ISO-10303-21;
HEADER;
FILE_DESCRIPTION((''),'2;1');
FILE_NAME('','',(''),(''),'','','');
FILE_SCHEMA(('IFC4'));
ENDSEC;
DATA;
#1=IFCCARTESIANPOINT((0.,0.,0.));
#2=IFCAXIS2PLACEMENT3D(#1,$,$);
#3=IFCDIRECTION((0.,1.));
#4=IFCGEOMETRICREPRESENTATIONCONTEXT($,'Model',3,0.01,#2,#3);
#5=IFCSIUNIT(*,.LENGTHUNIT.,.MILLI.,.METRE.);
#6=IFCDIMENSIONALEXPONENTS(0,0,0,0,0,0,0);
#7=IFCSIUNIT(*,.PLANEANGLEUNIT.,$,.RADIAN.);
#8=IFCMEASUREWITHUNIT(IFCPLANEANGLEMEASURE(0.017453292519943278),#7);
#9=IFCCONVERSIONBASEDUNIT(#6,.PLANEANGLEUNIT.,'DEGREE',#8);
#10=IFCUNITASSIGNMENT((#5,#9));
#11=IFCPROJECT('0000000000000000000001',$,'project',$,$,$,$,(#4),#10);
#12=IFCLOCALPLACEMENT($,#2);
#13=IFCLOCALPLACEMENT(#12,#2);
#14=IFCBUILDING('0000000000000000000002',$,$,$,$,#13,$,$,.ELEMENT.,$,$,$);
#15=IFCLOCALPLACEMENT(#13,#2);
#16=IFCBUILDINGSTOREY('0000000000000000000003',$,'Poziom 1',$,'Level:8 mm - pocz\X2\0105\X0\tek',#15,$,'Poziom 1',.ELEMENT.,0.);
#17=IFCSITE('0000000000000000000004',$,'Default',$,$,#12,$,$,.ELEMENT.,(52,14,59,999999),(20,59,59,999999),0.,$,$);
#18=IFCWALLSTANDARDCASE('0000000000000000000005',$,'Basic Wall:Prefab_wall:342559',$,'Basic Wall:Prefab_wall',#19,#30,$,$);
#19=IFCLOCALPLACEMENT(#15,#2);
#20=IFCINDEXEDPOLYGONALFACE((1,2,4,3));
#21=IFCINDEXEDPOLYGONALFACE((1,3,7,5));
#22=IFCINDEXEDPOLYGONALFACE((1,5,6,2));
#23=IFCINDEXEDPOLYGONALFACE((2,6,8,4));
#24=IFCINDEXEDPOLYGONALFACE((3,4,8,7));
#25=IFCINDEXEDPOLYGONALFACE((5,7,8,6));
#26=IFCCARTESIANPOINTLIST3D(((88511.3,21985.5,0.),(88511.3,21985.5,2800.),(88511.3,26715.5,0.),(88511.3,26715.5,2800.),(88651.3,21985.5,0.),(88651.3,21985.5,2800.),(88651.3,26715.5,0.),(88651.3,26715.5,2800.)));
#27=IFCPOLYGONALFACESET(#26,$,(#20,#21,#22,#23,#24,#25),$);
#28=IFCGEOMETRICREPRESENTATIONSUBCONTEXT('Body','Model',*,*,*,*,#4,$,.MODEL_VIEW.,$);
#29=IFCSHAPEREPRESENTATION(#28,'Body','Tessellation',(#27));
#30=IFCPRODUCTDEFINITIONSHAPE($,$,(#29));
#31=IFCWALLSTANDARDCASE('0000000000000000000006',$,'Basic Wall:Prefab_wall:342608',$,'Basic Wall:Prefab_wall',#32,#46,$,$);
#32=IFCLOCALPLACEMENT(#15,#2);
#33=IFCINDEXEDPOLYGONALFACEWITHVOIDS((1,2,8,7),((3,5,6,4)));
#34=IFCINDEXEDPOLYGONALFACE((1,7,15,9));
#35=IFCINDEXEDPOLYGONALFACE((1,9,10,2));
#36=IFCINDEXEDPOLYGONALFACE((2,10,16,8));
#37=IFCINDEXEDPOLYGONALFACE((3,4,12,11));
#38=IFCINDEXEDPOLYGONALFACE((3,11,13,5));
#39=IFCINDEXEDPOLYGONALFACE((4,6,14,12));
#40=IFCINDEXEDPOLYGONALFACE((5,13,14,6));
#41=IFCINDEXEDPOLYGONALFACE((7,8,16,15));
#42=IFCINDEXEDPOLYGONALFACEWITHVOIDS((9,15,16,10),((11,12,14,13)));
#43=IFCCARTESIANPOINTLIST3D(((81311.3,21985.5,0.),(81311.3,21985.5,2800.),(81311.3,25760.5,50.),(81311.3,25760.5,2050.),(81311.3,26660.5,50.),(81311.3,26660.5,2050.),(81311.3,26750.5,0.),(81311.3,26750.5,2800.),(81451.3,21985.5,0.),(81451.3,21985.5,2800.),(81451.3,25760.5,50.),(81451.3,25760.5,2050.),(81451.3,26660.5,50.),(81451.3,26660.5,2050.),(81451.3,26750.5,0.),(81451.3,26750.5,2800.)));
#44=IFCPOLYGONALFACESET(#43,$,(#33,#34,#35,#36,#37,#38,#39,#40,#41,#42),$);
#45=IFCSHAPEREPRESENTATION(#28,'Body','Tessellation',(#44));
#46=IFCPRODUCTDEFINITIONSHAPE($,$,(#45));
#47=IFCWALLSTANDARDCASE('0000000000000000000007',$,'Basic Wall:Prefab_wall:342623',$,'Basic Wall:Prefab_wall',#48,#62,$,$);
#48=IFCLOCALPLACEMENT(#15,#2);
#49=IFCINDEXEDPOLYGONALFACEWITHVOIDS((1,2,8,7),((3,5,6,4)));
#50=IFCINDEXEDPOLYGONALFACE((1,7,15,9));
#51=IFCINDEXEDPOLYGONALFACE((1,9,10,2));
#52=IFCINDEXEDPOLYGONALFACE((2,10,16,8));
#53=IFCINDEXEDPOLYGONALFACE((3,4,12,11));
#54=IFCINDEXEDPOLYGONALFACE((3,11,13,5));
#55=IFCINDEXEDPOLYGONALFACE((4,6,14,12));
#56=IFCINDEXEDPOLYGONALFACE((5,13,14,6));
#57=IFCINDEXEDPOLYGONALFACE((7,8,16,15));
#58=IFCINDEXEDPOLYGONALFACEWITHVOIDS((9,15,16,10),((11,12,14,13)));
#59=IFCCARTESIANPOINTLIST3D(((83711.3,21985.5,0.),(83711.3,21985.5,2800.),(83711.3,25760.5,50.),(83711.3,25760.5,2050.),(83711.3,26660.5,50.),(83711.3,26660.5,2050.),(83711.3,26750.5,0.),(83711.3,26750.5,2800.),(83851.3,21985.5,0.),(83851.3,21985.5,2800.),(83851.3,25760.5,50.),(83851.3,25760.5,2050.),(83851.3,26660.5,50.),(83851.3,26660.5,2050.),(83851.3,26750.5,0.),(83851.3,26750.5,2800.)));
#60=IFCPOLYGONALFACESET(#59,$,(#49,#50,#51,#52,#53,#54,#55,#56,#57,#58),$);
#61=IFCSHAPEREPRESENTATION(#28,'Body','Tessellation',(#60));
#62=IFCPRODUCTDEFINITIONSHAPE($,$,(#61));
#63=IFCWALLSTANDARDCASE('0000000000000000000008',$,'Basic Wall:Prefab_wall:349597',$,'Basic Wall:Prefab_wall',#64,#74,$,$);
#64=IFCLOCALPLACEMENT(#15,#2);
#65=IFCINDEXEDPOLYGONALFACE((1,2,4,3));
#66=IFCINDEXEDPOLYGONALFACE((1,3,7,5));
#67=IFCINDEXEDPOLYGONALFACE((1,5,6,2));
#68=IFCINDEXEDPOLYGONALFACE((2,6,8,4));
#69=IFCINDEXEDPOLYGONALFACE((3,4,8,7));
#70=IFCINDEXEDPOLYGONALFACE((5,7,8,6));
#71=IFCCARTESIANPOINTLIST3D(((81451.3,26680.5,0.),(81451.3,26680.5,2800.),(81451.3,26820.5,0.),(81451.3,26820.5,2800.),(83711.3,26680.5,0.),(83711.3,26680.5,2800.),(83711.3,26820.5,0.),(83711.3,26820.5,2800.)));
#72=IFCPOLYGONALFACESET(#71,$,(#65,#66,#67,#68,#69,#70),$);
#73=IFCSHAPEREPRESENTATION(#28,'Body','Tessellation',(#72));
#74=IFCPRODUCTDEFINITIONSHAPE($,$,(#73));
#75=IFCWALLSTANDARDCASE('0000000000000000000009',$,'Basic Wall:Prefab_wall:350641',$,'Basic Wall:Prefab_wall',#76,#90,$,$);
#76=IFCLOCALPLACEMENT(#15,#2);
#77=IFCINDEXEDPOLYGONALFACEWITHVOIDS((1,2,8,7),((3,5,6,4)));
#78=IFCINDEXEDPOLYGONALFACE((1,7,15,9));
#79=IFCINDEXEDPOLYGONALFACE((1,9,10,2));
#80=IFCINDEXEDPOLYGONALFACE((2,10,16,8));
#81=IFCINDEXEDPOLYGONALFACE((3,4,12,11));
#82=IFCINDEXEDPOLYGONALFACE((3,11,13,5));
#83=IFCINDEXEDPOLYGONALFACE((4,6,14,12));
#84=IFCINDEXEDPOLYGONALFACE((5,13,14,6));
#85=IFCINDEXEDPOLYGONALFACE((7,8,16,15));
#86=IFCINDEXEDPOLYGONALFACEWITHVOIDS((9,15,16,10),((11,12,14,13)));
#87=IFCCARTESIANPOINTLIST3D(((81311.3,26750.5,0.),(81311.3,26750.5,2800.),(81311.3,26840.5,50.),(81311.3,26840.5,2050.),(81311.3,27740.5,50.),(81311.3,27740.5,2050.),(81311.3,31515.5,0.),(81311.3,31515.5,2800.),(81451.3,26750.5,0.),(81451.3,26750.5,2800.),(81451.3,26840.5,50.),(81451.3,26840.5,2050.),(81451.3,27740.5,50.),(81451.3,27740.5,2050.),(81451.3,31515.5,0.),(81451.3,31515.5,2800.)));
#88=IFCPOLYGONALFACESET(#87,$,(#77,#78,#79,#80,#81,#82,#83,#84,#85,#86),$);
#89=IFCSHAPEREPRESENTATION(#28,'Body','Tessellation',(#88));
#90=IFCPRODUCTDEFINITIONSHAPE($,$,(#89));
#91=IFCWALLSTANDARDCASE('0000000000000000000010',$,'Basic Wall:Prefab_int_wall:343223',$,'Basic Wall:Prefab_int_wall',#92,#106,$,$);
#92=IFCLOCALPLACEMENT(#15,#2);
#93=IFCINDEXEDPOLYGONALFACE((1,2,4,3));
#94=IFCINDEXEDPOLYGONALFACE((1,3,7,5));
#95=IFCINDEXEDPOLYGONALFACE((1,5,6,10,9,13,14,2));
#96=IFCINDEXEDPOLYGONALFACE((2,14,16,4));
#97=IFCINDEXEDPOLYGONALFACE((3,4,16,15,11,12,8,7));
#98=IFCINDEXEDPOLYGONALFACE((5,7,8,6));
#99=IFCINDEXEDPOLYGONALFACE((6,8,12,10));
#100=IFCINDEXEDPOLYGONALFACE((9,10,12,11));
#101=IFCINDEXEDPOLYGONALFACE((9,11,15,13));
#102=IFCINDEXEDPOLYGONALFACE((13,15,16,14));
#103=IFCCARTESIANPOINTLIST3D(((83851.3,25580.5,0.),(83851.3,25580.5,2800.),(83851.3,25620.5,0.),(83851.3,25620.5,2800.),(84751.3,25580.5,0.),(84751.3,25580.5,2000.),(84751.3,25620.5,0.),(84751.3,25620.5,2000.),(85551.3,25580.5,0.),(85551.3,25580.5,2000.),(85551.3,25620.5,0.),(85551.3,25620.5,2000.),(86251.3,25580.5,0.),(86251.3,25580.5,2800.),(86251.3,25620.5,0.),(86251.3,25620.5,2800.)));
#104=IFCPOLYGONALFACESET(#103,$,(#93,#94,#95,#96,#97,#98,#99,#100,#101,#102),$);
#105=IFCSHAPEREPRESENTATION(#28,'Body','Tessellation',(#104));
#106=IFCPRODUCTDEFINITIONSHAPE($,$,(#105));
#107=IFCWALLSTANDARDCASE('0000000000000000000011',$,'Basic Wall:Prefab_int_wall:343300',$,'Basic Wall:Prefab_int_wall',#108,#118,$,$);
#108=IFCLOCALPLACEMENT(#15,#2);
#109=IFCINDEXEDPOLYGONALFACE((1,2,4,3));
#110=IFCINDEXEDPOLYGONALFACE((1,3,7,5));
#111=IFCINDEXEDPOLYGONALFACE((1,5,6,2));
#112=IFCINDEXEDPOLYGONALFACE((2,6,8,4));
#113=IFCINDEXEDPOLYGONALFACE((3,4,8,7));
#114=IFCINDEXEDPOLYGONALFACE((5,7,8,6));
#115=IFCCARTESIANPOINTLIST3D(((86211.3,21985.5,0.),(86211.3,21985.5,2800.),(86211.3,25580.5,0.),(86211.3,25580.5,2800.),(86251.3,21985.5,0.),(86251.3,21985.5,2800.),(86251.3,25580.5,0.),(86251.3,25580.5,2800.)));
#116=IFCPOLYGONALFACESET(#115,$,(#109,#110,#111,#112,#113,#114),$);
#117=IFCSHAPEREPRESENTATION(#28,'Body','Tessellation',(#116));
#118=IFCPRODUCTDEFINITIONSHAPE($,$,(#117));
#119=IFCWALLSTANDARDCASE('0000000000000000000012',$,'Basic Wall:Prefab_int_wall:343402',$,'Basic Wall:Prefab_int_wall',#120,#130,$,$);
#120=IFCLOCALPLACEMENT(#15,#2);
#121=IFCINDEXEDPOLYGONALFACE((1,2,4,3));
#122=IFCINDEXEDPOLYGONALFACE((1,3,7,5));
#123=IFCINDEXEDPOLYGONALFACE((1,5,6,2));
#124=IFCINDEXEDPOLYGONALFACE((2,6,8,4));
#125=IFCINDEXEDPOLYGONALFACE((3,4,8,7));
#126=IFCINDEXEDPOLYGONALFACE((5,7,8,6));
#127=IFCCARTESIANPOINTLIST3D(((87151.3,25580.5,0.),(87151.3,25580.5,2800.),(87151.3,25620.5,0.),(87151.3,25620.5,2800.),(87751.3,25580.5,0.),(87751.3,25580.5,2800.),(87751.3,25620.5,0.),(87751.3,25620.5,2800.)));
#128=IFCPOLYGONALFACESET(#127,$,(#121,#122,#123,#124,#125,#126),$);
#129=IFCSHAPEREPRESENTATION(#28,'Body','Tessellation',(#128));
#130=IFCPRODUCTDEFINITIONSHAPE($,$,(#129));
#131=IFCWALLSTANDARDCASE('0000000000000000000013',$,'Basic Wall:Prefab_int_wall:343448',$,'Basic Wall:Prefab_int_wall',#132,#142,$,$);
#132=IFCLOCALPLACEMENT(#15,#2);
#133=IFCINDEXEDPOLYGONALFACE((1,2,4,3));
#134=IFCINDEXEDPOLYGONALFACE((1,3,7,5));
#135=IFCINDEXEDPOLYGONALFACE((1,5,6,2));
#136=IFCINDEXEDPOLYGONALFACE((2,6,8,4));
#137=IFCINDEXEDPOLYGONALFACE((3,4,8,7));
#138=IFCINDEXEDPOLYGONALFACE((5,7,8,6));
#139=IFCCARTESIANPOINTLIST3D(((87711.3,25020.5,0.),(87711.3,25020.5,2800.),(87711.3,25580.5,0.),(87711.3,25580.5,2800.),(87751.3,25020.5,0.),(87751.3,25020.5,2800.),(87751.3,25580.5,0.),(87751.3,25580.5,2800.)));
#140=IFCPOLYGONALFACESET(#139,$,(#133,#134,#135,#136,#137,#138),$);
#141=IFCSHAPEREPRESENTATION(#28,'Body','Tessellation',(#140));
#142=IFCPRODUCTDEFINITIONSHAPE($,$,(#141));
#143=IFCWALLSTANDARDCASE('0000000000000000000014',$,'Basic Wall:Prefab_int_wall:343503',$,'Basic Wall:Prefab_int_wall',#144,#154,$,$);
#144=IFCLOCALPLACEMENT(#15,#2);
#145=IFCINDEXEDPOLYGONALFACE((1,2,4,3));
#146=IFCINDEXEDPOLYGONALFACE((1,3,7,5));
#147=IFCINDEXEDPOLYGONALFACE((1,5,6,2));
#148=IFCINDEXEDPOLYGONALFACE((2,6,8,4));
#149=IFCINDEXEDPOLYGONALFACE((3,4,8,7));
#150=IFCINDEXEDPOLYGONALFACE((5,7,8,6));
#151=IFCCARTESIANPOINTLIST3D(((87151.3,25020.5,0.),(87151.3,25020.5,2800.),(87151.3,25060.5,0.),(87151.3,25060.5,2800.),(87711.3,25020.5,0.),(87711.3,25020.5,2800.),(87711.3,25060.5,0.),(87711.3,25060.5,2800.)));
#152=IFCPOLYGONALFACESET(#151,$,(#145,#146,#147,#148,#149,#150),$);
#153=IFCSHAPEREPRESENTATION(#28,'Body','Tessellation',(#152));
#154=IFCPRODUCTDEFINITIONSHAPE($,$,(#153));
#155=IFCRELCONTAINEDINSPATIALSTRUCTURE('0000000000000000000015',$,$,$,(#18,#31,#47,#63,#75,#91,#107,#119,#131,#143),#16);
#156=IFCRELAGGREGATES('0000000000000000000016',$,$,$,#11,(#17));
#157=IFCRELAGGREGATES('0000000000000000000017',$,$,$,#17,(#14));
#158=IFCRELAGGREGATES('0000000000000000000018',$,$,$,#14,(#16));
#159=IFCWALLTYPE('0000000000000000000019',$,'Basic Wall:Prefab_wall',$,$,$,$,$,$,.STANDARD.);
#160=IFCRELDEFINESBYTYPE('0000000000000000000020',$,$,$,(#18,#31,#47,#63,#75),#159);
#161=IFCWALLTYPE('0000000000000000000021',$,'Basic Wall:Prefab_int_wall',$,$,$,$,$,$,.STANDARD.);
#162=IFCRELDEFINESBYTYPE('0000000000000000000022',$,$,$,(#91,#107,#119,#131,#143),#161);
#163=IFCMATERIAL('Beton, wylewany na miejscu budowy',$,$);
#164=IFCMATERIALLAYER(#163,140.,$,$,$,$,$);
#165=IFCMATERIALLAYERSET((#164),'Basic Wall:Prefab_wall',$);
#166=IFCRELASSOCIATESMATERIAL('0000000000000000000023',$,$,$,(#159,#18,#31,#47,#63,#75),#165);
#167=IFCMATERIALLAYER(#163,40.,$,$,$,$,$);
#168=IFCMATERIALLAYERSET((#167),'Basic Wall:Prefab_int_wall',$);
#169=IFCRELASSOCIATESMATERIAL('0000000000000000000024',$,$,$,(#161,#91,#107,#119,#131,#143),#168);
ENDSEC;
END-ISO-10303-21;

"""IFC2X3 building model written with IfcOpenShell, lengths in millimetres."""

from ifc_helpers import new_model, entity, si_unit, converted_unit, direction, frame, frame_2d, origin, origin_2d_with_axis, place, context, subcontext, project, spatial, rectangle, extrude, material, layer, layer_set, layer_usage, type_object, element, save


model = new_model("IFC2X3")

# Units and contexts
model_context = context("Model", 3, precision=0.01, world=origin(), true_north=direction((0.0, 1.0)))
body_context = subcontext(model_context, "Body", "Model", "MODEL_VIEW")
ifc_project = project(units=[si_unit("LENGTHUNIT", "METRE", prefix="MILLI"), converted_unit("PLANEANGLEUNIT", "DEGREE", entity("IfcPlaneAngleMeasure", 0.017453292519943278), si_unit("PLANEANGLEUNIT", "RADIAN"), dimensions=[0, 0, 0, 0, 0, 0, 0])], contexts=[model_context])

# Site, building, storey
site_placement = place(None, origin())
site = spatial("IfcSite", under=ifc_project, at=site_placement, Name="Default", CompositionType="ELEMENT", RefLatitude=(52, 14, 59, 999999), RefLongitude=(20, 59, 59, 999999), RefElevation=0.0)
building_placement = place(site_placement, origin())
building = spatial("IfcBuilding", under=site, at=building_placement, CompositionType="ELEMENT")
storey_placement = place(building_placement, origin())
storey = spatial("IfcBuildingStorey", under=building, at=storey_placement, Name="Poziom 1", ObjectType="Level:8 mm - początek", LongName="Poziom 1", CompositionType="ELEMENT", Elevation=0.0)

# Wall
ifc_material = material(Name="Beton, wylewany na miejscu budowy")
ifc_layer_1 = layer(ifc_material, 140.0)
ifc_layer_set_1 = layer_set([ifc_layer_1], Name="Basic Wall:Prefab_wall")
ifc_layer_usage_1 = layer_usage(ifc_layer_set_1, "AXIS2", "NEGATIVE", 70.0)
wall_type_1 = type_object("IfcWallType", Name="Basic Wall:Prefab_wall", PredefinedType="STANDARD", material=ifc_layer_set_1)
wall_1_placement = place(storey_placement, frame((88581.3, 21985.5, 0.0), z_axis=(0.0, 0.0, 1.0), x_axis=(0.0, 1.0, 0.0)))
element("IfcWallStandardCase", 1, at=wall_1_placement, inside=storey, type_object=wall_type_1, material=ifc_layer_usage_1, Name="Basic Wall:Prefab_wall:342559", ObjectType="Basic Wall:Prefab_wall", context=body_context, shape_type="SweptSolid", body=[
    extrude(rectangle(XDim=4730.0, YDim=140.0, at=frame_2d((2365.0, 0.0), x_axis=(-1.0, 0.0))), origin(), (0.0, 0.0, 1.0), 2800.0),
])

# Walls, openings
ifc_layer_usage_2 = layer_usage(ifc_layer_set_1, "AXIS2", "NEGATIVE", 70.0)
wall_2_placement = place(storey_placement, frame((81381.3, 21985.5, 0.0), z_axis=(0.0, 0.0, 1.0), x_axis=(0.0, 1.0, 0.0)))
wall_2 = element("IfcWallStandardCase", 2, at=wall_2_placement, inside=storey, type_object=wall_type_1, material=ifc_layer_usage_2, Name="Basic Wall:Prefab_wall:342608", ObjectType="Basic Wall:Prefab_wall", context=body_context, shape_type="SweptSolid", body=[
    extrude(rectangle(XDim=4765.0, YDim=140.0, at=frame_2d((2382.5, 0.0), x_axis=(-1.0, 0.0))), origin(), (0.0, 0.0, 1.0), 2800.0),
])
opening_1_placement = place(wall_2_placement, origin())
element("IfcOpeningElement", 3, at=opening_1_placement, cuts=wall_2, ObjectType="Opening", context=body_context, shape_type="SweptSolid", body=[
    extrude(rectangle(XDim=2000.0, YDim=900.0, at=frame_2d((0.0, 0.0), x_axis=(0.0, 1.0))), frame((4225.0, 70.0, 1050.0), z_axis=(0.0, -1.0, 0.0), x_axis=(1.0, 0.0, 0.0)), (0.0, 0.0, 1.0), 140.0),
])
ifc_layer_usage_3 = layer_usage(ifc_layer_set_1, "AXIS2", "NEGATIVE", 70.0)
wall_3_placement = place(storey_placement, frame((83781.3, 21985.5, 0.0), z_axis=(0.0, 0.0, 1.0), x_axis=(0.0, 1.0, 0.0)))
wall_3 = element("IfcWallStandardCase", 4, at=wall_3_placement, inside=storey, type_object=wall_type_1, material=ifc_layer_usage_3, Name="Basic Wall:Prefab_wall:342623", ObjectType="Basic Wall:Prefab_wall", context=body_context, shape_type="SweptSolid", body=[
    extrude(rectangle(XDim=4765.0, YDim=140.0, at=frame_2d((2382.5, 0.0), x_axis=(-1.0, 0.0))), origin(), (0.0, 0.0, 1.0), 2800.0),
])
opening_2_placement = place(wall_3_placement, origin())
element("IfcOpeningElement", 5, at=opening_2_placement, cuts=wall_3, ObjectType="Opening", context=body_context, shape_type="SweptSolid", body=[
    extrude(rectangle(XDim=2000.0, YDim=900.0, at=frame_2d((0.0, 0.0), x_axis=(0.0, 1.0))), frame((4225.0, 70.0, 1050.0), z_axis=(0.0, -1.0, 0.0), x_axis=(-1.0, 0.0, 0.0)), (0.0, 0.0, 1.0), 140.0),
])

# Wall
ifc_layer_usage_4 = layer_usage(ifc_layer_set_1, "AXIS2", "NEGATIVE", 70.0)
wall_4_placement = place(storey_placement, frame((81451.3, 26750.5, 0.0)))
element("IfcWallStandardCase", 6, at=wall_4_placement, inside=storey, type_object=wall_type_1, material=ifc_layer_usage_4, Name="Basic Wall:Prefab_wall:349597", ObjectType="Basic Wall:Prefab_wall", context=body_context, shape_type="SweptSolid", body=[
    extrude(rectangle(XDim=2260.0, YDim=140.0, at=frame_2d((1130.0, 0.0), x_axis=(-1.0, 0.0))), origin(), (0.0, 0.0, 1.0), 2800.0),
])

# Walls, openings
ifc_layer_usage_5 = layer_usage(ifc_layer_set_1, "AXIS2", "NEGATIVE", 70.0)
wall_5_placement = place(storey_placement, frame((81381.3, 26750.5, 0.0), z_axis=(0.0, 0.0, 1.0), x_axis=(0.0, 1.0, 0.0)))
wall_5 = element("IfcWallStandardCase", 7, at=wall_5_placement, inside=storey, type_object=wall_type_1, material=ifc_layer_usage_5, Name="Basic Wall:Prefab_wall:350641", ObjectType="Basic Wall:Prefab_wall", context=body_context, shape_type="SweptSolid", body=[
    extrude(rectangle(XDim=4765.0, YDim=140.0, at=frame_2d((2382.5, 0.0), x_axis=(-1.0, 0.0))), origin(), (0.0, 0.0, 1.0), 2800.0),
])
opening_3_placement = place(wall_5_placement, origin())
element("IfcOpeningElement", 8, at=opening_3_placement, cuts=wall_5, ObjectType="Opening", context=body_context, shape_type="SweptSolid", body=[
    extrude(rectangle(XDim=2000.0, YDim=900.0, at=origin_2d_with_axis()), frame((540.0, 70.0, 1050.0), z_axis=(0.0, -1.0, 0.0), x_axis=(0.0, 0.0, -1.0)), (0.0, 0.0, 1.0), 140.0),
])
ifc_layer_2 = layer(ifc_material, 40.0)
ifc_layer_set_2 = layer_set([ifc_layer_2], Name="Basic Wall:Prefab_int_wall")
ifc_layer_usage_6 = layer_usage(ifc_layer_set_2, "AXIS2", "NEGATIVE", 20.0)
wall_type_2 = type_object("IfcWallType", Name="Basic Wall:Prefab_int_wall", PredefinedType="STANDARD", material=ifc_layer_set_2)
wall_6_placement = place(storey_placement, frame((83851.3, 25600.5, 0.0)))
wall_6 = element("IfcWallStandardCase", 9, at=wall_6_placement, inside=storey, type_object=wall_type_2, material=ifc_layer_usage_6, Name="Basic Wall:Prefab_int_wall:343223", ObjectType="Basic Wall:Prefab_int_wall", context=body_context, shape_type="SweptSolid", body=[
    extrude(rectangle(XDim=2400.0, YDim=40.0, at=frame_2d((1200.0, 0.0), x_axis=(-1.0, 0.0))), origin(), (0.0, 0.0, 1.0), 2800.0),
])
opening_4_placement = place(wall_6_placement, origin())
element("IfcOpeningElement", 10, at=opening_4_placement, cuts=wall_6, ObjectType="Opening", context=body_context, shape_type="SweptSolid", body=[
    extrude(rectangle(XDim=2000.0, YDim=800.0, at=frame_2d((0.0, 0.0), x_axis=(0.0, 1.0))), frame((1300.0, 20.0, 1000.0), z_axis=(0.0, -1.0, 0.0), x_axis=(1.0, 0.0, 0.0)), (0.0, 0.0, 1.0), 40.0),
])

# Walls
ifc_layer_usage_7 = layer_usage(ifc_layer_set_2, "AXIS2", "NEGATIVE", 20.0)
wall_7_placement = place(storey_placement, frame((86231.3, 25580.5, 0.0), z_axis=(0.0, 0.0, 1.0), x_axis=(0.0, -1.0, 0.0)))
element("IfcWallStandardCase", 11, at=wall_7_placement, inside=storey, type_object=wall_type_2, material=ifc_layer_usage_7, Name="Basic Wall:Prefab_int_wall:343300", ObjectType="Basic Wall:Prefab_int_wall", context=body_context, shape_type="SweptSolid", body=[
    extrude(rectangle(XDim=3595.0, YDim=40.0, at=frame_2d((1797.5, 0.0), x_axis=(-1.0, 0.0))), origin(), (0.0, 0.0, 1.0), 2800.0),
])
ifc_layer_usage_8 = layer_usage(ifc_layer_set_2, "AXIS2", "NEGATIVE", 20.0)
wall_8_placement = place(storey_placement, frame((87151.3, 25600.5, 0.0)))
element("IfcWallStandardCase", 12, at=wall_8_placement, inside=storey, type_object=wall_type_2, material=ifc_layer_usage_8, Name="Basic Wall:Prefab_int_wall:343402", ObjectType="Basic Wall:Prefab_int_wall", context=body_context, shape_type="SweptSolid", body=[
    extrude(rectangle(XDim=600.0, YDim=40.0, at=frame_2d((300.0, 0.0), x_axis=(-1.0, 0.0))), origin(), (0.0, 0.0, 1.0), 2800.0),
])
ifc_layer_usage_9 = layer_usage(ifc_layer_set_2, "AXIS2", "NEGATIVE", 20.0)
wall_9_placement = place(storey_placement, frame((87731.3, 25580.5, 0.0), z_axis=(0.0, 0.0, 1.0), x_axis=(0.0, -1.0, 0.0)))
element("IfcWallStandardCase", 13, at=wall_9_placement, inside=storey, type_object=wall_type_2, material=ifc_layer_usage_9, Name="Basic Wall:Prefab_int_wall:343448", ObjectType="Basic Wall:Prefab_int_wall", context=body_context, shape_type="SweptSolid", body=[
    extrude(rectangle(XDim=560.0, YDim=40.0, at=frame_2d((280.0, 0.0), x_axis=(-1.0, 0.0))), origin(), (0.0, 0.0, 1.0), 2800.0),
])
ifc_layer_usage_10 = layer_usage(ifc_layer_set_2, "AXIS2", "NEGATIVE", 20.0)
wall_10_placement = place(storey_placement, frame((87711.3, 25040.5, 0.0), z_axis=(0.0, 0.0, 1.0), x_axis=(-1.0, 0.0, 0.0)))
element("IfcWallStandardCase", 14, at=wall_10_placement, inside=storey, type_object=wall_type_2, material=ifc_layer_usage_10, Name="Basic Wall:Prefab_int_wall:343503", ObjectType="Basic Wall:Prefab_int_wall", context=body_context, shape_type="SweptSolid", body=[
    extrude(rectangle(XDim=560.0, YDim=40.0, at=frame_2d((280.0, 0.0), x_axis=(-1.0, 0.0))), origin(), (0.0, 0.0, 1.0), 2800.0),
])

save(model, "model.ifc")
